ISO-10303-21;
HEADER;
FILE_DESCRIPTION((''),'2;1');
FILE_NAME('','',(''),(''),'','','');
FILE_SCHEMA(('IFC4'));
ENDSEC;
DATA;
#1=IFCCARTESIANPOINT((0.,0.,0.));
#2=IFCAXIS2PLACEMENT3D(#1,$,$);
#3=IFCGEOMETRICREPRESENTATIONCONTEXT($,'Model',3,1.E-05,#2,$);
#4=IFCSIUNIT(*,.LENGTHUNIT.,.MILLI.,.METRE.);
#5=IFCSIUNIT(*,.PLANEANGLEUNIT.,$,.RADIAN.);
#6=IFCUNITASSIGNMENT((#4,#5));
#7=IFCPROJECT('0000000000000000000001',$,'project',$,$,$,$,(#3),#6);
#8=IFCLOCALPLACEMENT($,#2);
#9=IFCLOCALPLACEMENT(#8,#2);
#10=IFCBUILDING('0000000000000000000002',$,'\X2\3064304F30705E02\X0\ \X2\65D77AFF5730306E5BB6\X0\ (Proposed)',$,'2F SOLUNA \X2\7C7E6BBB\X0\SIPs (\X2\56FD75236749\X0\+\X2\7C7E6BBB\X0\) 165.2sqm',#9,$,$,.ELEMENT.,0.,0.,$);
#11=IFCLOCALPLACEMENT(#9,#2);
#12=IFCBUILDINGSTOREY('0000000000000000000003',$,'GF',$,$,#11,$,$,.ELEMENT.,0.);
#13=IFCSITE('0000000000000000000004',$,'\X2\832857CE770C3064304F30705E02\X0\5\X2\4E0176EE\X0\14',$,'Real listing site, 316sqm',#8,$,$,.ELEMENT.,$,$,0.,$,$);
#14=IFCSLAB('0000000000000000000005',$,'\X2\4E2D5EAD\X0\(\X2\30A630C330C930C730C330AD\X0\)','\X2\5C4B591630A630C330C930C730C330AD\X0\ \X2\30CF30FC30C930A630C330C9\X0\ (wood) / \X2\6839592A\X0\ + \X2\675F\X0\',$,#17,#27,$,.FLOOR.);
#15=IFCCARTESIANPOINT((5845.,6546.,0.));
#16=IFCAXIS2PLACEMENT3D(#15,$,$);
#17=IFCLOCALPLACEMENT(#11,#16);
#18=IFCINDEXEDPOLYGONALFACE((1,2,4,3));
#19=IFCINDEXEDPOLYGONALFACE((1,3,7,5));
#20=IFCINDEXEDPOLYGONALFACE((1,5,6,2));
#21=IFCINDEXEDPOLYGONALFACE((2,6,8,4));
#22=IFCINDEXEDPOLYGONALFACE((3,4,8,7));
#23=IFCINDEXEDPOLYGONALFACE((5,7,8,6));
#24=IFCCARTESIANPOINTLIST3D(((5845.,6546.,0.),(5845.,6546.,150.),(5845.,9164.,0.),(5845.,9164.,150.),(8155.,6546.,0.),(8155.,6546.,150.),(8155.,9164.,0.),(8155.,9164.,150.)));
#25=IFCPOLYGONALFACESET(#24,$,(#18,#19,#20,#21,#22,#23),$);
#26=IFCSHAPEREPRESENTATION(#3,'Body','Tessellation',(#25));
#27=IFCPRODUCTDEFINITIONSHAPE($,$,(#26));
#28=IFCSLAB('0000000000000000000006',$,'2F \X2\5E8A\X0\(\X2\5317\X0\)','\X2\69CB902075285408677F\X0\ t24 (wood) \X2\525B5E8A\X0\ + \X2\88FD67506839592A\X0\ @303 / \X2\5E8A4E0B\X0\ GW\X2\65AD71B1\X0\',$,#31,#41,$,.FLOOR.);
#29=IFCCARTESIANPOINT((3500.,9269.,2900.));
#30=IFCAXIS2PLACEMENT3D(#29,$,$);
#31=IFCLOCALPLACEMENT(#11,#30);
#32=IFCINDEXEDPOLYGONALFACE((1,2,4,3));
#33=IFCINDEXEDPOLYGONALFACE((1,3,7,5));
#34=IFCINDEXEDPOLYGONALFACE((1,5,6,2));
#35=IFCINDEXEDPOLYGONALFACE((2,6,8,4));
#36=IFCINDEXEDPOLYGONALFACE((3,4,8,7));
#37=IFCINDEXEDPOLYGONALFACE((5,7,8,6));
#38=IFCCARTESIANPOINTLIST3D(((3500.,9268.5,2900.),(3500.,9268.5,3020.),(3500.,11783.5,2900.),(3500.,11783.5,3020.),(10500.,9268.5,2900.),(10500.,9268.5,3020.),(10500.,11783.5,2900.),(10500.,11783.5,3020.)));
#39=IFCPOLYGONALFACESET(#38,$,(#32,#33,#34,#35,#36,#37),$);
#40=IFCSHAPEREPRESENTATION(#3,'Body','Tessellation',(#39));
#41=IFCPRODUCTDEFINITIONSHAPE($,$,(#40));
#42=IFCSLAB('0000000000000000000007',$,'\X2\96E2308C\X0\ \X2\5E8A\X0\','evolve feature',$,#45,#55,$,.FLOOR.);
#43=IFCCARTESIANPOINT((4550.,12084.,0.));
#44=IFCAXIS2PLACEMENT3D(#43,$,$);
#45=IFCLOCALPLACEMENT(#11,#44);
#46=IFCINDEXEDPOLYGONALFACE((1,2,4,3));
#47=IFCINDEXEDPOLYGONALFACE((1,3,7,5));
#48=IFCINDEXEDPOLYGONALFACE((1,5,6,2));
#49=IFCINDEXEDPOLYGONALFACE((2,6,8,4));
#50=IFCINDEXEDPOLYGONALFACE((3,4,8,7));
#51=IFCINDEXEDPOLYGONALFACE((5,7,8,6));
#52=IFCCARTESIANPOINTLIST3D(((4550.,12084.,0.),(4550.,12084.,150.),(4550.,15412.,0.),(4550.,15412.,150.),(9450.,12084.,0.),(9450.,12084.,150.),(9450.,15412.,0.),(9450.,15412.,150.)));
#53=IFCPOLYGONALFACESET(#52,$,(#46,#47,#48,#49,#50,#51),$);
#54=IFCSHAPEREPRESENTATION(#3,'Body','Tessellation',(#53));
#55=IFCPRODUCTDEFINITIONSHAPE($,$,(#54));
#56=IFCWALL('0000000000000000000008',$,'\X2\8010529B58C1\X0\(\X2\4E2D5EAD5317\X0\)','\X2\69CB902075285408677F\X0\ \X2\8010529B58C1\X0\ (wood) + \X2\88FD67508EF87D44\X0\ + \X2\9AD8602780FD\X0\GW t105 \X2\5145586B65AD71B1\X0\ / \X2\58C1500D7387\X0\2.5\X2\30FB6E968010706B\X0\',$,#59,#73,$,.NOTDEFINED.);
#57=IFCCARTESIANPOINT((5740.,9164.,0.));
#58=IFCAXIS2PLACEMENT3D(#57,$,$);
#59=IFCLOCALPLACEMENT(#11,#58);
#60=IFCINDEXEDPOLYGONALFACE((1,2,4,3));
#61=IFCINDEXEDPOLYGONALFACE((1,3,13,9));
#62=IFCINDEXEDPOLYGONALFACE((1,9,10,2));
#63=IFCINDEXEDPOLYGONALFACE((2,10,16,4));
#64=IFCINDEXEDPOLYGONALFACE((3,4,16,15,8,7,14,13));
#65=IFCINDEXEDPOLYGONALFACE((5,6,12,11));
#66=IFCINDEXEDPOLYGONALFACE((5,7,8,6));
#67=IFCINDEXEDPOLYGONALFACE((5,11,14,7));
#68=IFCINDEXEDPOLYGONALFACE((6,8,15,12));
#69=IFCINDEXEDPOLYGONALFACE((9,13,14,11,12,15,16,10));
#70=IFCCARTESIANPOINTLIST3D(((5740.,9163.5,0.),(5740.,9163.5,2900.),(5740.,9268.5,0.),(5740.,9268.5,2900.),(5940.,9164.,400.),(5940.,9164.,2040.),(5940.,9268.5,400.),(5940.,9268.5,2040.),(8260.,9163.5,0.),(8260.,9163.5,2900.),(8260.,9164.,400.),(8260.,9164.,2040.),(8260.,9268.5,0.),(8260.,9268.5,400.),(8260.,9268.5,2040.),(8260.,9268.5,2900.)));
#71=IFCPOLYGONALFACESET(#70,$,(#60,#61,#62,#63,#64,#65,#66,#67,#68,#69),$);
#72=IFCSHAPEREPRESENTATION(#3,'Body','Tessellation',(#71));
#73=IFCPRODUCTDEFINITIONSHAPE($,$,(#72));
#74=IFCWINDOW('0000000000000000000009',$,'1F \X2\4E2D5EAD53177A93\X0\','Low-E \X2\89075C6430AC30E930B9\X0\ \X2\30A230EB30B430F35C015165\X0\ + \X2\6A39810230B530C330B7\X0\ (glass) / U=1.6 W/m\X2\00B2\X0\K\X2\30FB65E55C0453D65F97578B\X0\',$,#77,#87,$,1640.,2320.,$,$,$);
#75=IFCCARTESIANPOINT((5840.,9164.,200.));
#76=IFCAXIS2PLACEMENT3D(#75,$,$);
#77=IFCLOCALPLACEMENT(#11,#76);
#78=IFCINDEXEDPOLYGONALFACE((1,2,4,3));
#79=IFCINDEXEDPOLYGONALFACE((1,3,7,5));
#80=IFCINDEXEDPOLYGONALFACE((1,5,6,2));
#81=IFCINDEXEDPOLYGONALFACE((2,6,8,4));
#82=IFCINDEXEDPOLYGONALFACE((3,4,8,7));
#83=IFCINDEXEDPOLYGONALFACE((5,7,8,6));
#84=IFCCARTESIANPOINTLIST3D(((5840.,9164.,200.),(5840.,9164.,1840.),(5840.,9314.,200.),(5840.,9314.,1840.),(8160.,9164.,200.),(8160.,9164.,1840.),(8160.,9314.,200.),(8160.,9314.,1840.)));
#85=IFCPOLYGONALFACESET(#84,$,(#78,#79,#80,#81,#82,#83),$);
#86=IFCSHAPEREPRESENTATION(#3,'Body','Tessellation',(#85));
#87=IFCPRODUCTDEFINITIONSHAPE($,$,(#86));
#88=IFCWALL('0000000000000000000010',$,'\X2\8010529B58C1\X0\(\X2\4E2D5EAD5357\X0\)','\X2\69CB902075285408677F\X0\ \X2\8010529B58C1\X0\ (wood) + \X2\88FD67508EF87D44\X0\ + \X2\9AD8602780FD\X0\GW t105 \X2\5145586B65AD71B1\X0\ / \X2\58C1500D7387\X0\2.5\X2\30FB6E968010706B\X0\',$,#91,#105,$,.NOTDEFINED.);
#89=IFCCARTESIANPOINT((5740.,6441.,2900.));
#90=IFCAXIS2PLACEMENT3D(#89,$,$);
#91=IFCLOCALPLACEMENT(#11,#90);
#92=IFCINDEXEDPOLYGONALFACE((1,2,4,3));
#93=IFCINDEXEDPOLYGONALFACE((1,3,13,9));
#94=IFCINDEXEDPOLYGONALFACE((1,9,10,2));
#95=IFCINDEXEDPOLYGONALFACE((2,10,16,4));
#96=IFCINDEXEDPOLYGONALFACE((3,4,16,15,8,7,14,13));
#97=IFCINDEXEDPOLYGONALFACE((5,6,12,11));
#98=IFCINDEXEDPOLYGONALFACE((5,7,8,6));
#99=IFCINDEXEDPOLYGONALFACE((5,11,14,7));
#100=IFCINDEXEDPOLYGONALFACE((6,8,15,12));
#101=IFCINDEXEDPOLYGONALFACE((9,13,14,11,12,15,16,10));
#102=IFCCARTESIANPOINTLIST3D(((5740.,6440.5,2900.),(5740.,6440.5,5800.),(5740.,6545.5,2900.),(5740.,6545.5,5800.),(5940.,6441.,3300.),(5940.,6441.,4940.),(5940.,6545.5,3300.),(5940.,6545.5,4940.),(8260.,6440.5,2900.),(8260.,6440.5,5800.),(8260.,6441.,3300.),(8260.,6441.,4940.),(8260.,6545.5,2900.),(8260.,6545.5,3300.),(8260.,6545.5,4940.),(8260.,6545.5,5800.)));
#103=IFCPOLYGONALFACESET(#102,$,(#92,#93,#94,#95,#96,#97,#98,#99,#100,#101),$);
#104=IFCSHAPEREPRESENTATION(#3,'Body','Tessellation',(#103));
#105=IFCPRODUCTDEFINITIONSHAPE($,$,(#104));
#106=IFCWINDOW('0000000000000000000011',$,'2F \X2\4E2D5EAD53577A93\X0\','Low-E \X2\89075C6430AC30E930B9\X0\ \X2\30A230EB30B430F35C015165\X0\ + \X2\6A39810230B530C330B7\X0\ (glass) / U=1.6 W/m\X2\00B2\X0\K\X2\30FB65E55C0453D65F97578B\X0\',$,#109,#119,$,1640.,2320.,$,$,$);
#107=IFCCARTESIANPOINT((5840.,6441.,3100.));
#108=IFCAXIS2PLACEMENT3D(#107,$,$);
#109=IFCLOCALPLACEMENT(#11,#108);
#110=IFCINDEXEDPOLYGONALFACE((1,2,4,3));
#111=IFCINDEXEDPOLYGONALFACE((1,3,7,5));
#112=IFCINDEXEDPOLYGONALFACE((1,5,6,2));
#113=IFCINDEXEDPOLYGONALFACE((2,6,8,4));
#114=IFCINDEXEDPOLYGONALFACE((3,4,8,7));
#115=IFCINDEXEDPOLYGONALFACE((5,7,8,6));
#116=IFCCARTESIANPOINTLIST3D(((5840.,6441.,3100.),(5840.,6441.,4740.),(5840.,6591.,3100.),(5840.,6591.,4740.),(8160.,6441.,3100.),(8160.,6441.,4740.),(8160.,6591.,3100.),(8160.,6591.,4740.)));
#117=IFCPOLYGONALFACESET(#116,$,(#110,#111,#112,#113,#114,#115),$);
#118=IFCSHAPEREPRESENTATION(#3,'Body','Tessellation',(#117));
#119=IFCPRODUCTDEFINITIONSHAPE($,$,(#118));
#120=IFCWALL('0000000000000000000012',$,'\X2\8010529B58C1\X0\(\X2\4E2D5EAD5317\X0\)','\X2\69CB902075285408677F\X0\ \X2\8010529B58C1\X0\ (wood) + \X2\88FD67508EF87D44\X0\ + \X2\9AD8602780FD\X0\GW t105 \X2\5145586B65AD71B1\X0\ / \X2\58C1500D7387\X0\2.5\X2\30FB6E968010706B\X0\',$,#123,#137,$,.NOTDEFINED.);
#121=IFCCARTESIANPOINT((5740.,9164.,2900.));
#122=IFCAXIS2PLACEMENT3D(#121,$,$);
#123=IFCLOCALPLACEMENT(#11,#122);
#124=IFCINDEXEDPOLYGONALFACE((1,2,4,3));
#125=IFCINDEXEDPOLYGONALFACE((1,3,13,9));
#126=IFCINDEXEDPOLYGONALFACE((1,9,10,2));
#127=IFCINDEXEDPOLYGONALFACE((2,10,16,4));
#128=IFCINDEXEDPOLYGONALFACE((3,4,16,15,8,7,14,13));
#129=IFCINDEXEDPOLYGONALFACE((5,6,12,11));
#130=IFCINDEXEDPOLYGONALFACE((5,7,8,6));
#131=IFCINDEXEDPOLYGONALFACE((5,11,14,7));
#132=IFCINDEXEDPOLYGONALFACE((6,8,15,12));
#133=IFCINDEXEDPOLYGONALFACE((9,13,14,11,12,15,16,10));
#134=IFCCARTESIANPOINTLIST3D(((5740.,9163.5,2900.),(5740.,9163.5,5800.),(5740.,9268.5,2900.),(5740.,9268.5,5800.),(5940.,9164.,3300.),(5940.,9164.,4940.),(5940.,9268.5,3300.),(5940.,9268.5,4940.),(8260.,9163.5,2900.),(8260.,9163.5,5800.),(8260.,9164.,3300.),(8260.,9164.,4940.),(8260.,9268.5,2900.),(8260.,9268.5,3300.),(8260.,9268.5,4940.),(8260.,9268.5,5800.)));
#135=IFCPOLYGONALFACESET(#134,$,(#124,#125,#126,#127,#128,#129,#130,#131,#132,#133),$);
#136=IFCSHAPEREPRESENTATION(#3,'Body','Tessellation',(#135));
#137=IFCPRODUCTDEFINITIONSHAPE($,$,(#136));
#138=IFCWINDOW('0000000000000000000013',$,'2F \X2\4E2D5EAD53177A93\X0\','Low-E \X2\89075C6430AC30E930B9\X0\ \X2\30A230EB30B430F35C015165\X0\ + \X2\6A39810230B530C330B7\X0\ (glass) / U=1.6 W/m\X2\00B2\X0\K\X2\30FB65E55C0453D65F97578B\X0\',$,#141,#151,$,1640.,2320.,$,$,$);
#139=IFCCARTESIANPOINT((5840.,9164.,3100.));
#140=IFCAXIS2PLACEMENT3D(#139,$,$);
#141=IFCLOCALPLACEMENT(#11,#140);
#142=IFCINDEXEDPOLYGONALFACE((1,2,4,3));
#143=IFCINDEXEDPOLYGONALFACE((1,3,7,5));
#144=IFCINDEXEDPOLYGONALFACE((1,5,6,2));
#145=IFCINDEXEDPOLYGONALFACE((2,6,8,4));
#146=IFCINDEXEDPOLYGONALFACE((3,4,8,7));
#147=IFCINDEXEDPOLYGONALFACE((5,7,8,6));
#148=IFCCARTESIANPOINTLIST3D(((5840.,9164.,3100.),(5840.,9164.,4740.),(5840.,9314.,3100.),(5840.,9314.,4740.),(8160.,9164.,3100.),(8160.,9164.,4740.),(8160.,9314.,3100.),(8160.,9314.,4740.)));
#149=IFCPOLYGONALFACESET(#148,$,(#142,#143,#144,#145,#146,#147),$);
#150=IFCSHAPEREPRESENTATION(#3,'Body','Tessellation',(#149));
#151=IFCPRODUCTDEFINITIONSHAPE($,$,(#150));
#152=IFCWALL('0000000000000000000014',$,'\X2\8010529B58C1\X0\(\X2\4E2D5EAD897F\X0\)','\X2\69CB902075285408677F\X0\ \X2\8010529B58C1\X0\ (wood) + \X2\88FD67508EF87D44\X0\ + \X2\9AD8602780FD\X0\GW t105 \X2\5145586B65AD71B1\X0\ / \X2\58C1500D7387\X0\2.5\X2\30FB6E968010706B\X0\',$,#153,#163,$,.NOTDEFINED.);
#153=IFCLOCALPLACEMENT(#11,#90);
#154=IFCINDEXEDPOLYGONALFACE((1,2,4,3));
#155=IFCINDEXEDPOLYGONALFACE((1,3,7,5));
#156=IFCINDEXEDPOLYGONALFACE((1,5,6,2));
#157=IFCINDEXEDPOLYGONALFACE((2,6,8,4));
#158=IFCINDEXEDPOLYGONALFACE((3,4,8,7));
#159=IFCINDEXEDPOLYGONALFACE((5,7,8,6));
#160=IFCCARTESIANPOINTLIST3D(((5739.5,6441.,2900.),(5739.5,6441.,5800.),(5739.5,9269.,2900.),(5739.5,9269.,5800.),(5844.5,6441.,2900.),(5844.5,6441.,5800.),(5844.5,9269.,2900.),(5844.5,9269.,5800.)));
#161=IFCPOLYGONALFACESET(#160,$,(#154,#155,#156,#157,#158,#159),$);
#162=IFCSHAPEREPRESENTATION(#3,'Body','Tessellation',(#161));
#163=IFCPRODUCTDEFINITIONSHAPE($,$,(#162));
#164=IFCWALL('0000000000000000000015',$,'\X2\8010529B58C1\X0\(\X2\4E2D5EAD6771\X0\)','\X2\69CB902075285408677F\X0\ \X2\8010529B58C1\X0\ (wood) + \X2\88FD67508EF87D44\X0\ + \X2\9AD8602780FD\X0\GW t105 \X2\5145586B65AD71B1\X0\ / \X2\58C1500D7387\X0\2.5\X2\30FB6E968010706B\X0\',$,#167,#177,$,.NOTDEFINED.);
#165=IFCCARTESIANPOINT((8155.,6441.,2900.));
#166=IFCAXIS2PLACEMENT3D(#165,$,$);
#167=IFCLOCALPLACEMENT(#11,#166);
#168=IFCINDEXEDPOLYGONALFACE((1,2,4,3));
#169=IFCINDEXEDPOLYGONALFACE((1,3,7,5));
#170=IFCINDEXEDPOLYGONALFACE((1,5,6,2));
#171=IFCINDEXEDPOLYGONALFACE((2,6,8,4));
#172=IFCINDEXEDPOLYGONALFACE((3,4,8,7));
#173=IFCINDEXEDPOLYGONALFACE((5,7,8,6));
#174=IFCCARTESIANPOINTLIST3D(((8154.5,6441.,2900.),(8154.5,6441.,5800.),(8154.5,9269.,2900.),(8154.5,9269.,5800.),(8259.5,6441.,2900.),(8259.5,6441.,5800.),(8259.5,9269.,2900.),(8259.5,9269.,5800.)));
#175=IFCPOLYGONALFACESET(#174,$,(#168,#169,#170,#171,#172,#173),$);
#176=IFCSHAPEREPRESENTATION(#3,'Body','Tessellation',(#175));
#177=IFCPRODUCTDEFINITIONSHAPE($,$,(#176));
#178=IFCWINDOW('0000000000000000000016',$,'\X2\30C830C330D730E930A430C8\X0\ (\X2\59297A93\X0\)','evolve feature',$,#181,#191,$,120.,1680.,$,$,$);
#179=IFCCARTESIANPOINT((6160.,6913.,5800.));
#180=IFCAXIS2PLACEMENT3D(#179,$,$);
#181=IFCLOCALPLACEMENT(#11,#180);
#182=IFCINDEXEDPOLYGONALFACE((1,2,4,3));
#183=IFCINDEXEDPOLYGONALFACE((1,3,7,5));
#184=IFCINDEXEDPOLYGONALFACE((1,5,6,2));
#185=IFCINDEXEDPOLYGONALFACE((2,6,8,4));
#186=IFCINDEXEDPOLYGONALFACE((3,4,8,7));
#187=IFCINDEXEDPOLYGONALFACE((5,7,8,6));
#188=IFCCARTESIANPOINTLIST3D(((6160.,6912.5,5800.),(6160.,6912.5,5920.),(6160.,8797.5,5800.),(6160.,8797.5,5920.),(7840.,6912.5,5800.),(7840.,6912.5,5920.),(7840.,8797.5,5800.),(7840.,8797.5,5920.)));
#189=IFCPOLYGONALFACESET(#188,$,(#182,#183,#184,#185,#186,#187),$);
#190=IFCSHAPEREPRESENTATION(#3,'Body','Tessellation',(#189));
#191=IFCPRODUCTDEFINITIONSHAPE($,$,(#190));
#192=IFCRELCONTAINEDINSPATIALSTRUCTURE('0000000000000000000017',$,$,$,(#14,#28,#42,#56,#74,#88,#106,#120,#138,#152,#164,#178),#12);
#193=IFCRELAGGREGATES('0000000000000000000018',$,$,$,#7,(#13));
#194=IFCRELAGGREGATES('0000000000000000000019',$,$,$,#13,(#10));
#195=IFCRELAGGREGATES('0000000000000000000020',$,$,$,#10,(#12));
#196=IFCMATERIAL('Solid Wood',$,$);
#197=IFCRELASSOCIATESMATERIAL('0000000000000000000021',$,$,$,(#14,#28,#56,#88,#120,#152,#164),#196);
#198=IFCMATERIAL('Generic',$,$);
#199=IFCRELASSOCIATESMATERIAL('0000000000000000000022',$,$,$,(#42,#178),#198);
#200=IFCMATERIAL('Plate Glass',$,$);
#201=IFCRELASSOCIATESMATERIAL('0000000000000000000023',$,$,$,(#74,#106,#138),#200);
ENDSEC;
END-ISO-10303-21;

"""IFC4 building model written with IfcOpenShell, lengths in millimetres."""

from ifc_helpers import new_model, si_unit, frame, frame_2d, origin, place, context, project, spatial, rectangle, extrude, material, element, fill, save


model = new_model("IFC4")

# Units and contexts
model_context = context("Model", 3, precision=1e-05, world=origin())
ifc_project = project(units=[si_unit("LENGTHUNIT", "METRE", prefix="MILLI"), si_unit("PLANEANGLEUNIT", "RADIAN")], contexts=[model_context])

# Site, building, storey
site_placement = place(None, origin())
site = spatial("IfcSite", under=ifc_project, at=site_placement, Name="茨城県つくば市5丁目14", ObjectType="Real listing site, 316sqm", CompositionType="ELEMENT", RefElevation=0.0)
building_placement = place(site_placement, origin())
building = spatial("IfcBuilding", under=site, at=building_placement, Name="つくば市 旗竿地の家 (Proposed)", ObjectType="2F SOLUNA 籾殻SIPs (国産杉+籾殻) 165.2sqm", CompositionType="ELEMENT", ElevationOfRefHeight=0.0, ElevationOfTerrain=0.0)
storey_placement = place(building_placement, origin())
storey = spatial("IfcBuildingStorey", under=building, at=storey_placement, Name="GF", CompositionType="ELEMENT", Elevation=0.0)

# Slabs
ifc_material_1 = material(Name="Solid Wood")
slab_1_placement = place(storey_placement, frame((5845.0, 6546.0, 0.0)))
element("IfcSlab", 1, at=slab_1_placement, inside=storey, material=ifc_material_1, Name="中庭(ウッドデッキ)", Description="屋外ウッドデッキ ハードウッド (wood) / 根太 + 束", PredefinedType="FLOOR", context=model_context, shape_type="SweptSolid", body=[
    extrude(rectangle(XDim=2310.0, YDim=2618.0, at=frame_2d((1155.0, 1309.0))), frame((5845.0, 6546.0, 0.0)), (0.0, 0.0, 1.0), 150.0),
])
slab_2_placement = place(storey_placement, frame((3500.0, 9269.0, 2900.0)))
element("IfcSlab", 2, at=slab_2_placement, inside=storey, material=ifc_material_1, Name="2F 床(北)", Description="構造用合板 t24 (wood) 剛床 + 製材根太 @303 / 床下 GW断熱", PredefinedType="FLOOR", context=model_context, shape_type="SweptSolid", body=[
    extrude(rectangle(XDim=7000.0, YDim=2515.0, at=frame_2d((3500.0, 1257.0))), frame((3500.0, 9269.0, 2900.0)), (0.0, 0.0, 1.0), 120.0),
])
ifc_material_2 = material(Name="Generic")
slab_3_placement = place(storey_placement, frame((4550.0, 12084.0, 0.0)))
element("IfcSlab", 3, at=slab_3_placement, inside=storey, material=ifc_material_2, Name="離れ 床", Description="evolve feature", PredefinedType="FLOOR", context=model_context, shape_type="SweptSolid", body=[
    extrude(rectangle(XDim=4900.0, YDim=3328.0, at=frame_2d((2450.0, 1664.0))), frame((4550.0, 12084.0, 0.0)), (0.0, 0.0, 1.0), 150.0),
])

# Wall, opening, window
wall_1_placement = place(storey_placement, frame((5740.0, 9164.0, 0.0)))
wall_1 = element("IfcWall", 4, at=wall_1_placement, inside=storey, material=ifc_material_1, Name="耐力壁(中庭北)", Description="構造用合板 耐力壁 (wood) + 製材軸組 + 高性能GW t105 充填断熱 / 壁倍率2.5・準耐火", PredefinedType="NOTDEFINED", context=model_context, shape_type="SweptSolid", body=[
    extrude(rectangle(XDim=2520.0, YDim=105.0, at=frame_2d((1260.0, 52.0))), frame((5740.0, 9164.0, 0.0)), (0.0, 0.0, 1.0), 2900.0),
])
opening_1_placement = place(storey_placement, frame((5840.0, 9164.0, 200.0)))
opening_1 = element("IfcOpeningElement", 5, at=opening_1_placement, cuts=wall_1, PredefinedType="NOTDEFINED", context=model_context, shape_type="SweptSolid", body=[
    extrude(rectangle(XDim=2320.0, YDim=150.0, at=frame_2d((1160.0, 75.0))), frame((5840.0, 9164.0, 200.0)), (0.0, 0.0, 1.0), 1640.0),
])
ifc_material_3 = material(Name="Plate Glass")
window_1_placement = place(storey_placement, frame((5840.0, 9164.0, 200.0)))
window_1 = element("IfcWindow", 6, at=window_1_placement, inside=storey, material=ifc_material_3, Name="1F 中庭北窓", Description="Low-E 複層ガラス アルゴン封入 + 樹脂サッシ (glass) / U=1.6 W/m²K・日射取得型", OverallHeight=1640.0, OverallWidth=2320.0, context=model_context, shape_type="SweptSolid", body=[
    extrude(rectangle(XDim=2320.0, YDim=150.0, at=frame_2d((1160.0, 75.0))), frame((5840.0, 9164.0, 200.0)), (0.0, 0.0, 1.0), 1640.0),
])
fill(opening_1, window_1)

# Walls, openings, windows
wall_2_placement = place(storey_placement, frame((5740.0, 6441.0, 2900.0)))
wall_2 = element("IfcWall", 7, at=wall_2_placement, inside=storey, material=ifc_material_1, Name="耐力壁(中庭南)", Description="構造用合板 耐力壁 (wood) + 製材軸組 + 高性能GW t105 充填断熱 / 壁倍率2.5・準耐火", PredefinedType="NOTDEFINED", context=model_context, shape_type="SweptSolid", body=[
    extrude(rectangle(XDim=2520.0, YDim=105.0, at=frame_2d((1260.0, 52.0))), frame((5740.0, 6441.0, 2900.0)), (0.0, 0.0, 1.0), 2900.0),
])
opening_2_placement = place(storey_placement, frame((5840.0, 6441.0, 3100.0)))
opening_2 = element("IfcOpeningElement", 8, at=opening_2_placement, cuts=wall_2, PredefinedType="NOTDEFINED", context=model_context, shape_type="SweptSolid", body=[
    extrude(rectangle(XDim=2320.0, YDim=150.0, at=frame_2d((1160.0, 75.0))), frame((5840.0, 6441.0, 3100.0)), (0.0, 0.0, 1.0), 1640.0),
])
window_2_placement = place(storey_placement, frame((5840.0, 6441.0, 3100.0)))
window_2 = element("IfcWindow", 9, at=window_2_placement, inside=storey, material=ifc_material_3, Name="2F 中庭南窓", Description="Low-E 複層ガラス アルゴン封入 + 樹脂サッシ (glass) / U=1.6 W/m²K・日射取得型", OverallHeight=1640.0, OverallWidth=2320.0, context=model_context, shape_type="SweptSolid", body=[
    extrude(rectangle(XDim=2320.0, YDim=150.0, at=frame_2d((1160.0, 75.0))), frame((5840.0, 6441.0, 3100.0)), (0.0, 0.0, 1.0), 1640.0),
])
fill(opening_2, window_2)
wall_3_placement = place(storey_placement, frame((5740.0, 9164.0, 2900.0)))
wall_3 = element("IfcWall", 10, at=wall_3_placement, inside=storey, material=ifc_material_1, Name="耐力壁(中庭北)", Description="構造用合板 耐力壁 (wood) + 製材軸組 + 高性能GW t105 充填断熱 / 壁倍率2.5・準耐火", PredefinedType="NOTDEFINED", context=model_context, shape_type="SweptSolid", body=[
    extrude(rectangle(XDim=2520.0, YDim=105.0, at=frame_2d((1260.0, 52.0))), frame((5740.0, 9164.0, 2900.0)), (0.0, 0.0, 1.0), 2900.0),
])
opening_3_placement = place(storey_placement, frame((5840.0, 9164.0, 3100.0)))
opening_3 = element("IfcOpeningElement", 11, at=opening_3_placement, cuts=wall_3, PredefinedType="NOTDEFINED", context=model_context, shape_type="SweptSolid", body=[
    extrude(rectangle(XDim=2320.0, YDim=150.0, at=frame_2d((1160.0, 75.0))), frame((5840.0, 9164.0, 3100.0)), (0.0, 0.0, 1.0), 1640.0),
])
window_3_placement = place(storey_placement, frame((5840.0, 9164.0, 3100.0)))
window_3 = element("IfcWindow", 12, at=window_3_placement, inside=storey, material=ifc_material_3, Name="2F 中庭北窓", Description="Low-E 複層ガラス アルゴン封入 + 樹脂サッシ (glass) / U=1.6 W/m²K・日射取得型", OverallHeight=1640.0, OverallWidth=2320.0, context=model_context, shape_type="SweptSolid", body=[
    extrude(rectangle(XDim=2320.0, YDim=150.0, at=frame_2d((1160.0, 75.0))), frame((5840.0, 9164.0, 3100.0)), (0.0, 0.0, 1.0), 1640.0),
])
fill(opening_3, window_3)

# Walls
wall_4_placement = place(storey_placement, frame((5740.0, 6441.0, 2900.0)))
element("IfcWall", 13, at=wall_4_placement, inside=storey, material=ifc_material_1, Name="耐力壁(中庭西)", Description="構造用合板 耐力壁 (wood) + 製材軸組 + 高性能GW t105 充填断熱 / 壁倍率2.5・準耐火", PredefinedType="NOTDEFINED", context=model_context, shape_type="SweptSolid", body=[
    extrude(rectangle(XDim=105.0, YDim=2828.0, at=frame_2d((52.0, 1414.0))), frame((5740.0, 6441.0, 2900.0)), (0.0, 0.0, 1.0), 2900.0),
])
wall_5_placement = place(storey_placement, frame((8155.0, 6441.0, 2900.0)))
element("IfcWall", 14, at=wall_5_placement, inside=storey, material=ifc_material_1, Name="耐力壁(中庭東)", Description="構造用合板 耐力壁 (wood) + 製材軸組 + 高性能GW t105 充填断熱 / 壁倍率2.5・準耐火", PredefinedType="NOTDEFINED", context=model_context, shape_type="SweptSolid", body=[
    extrude(rectangle(XDim=105.0, YDim=2828.0, at=frame_2d((52.0, 1414.0))), frame((8155.0, 6441.0, 2900.0)), (0.0, 0.0, 1.0), 2900.0),
])

# Window
window_4_placement = place(storey_placement, frame((6160.0, 6913.0, 5800.0)))
element("IfcWindow", 15, at=window_4_placement, inside=storey, material=ifc_material_2, Name="トップライト (天窓)", Description="evolve feature", OverallHeight=120.0, OverallWidth=1680.0, context=model_context, shape_type="SweptSolid", body=[
    extrude(rectangle(XDim=1680.0, YDim=1885.0, at=frame_2d((840.0, 942.0))), frame((6160.0, 6913.0, 5800.0)), (0.0, 0.0, 1.0), 120.0),
])

save(model, "model.ifc")
